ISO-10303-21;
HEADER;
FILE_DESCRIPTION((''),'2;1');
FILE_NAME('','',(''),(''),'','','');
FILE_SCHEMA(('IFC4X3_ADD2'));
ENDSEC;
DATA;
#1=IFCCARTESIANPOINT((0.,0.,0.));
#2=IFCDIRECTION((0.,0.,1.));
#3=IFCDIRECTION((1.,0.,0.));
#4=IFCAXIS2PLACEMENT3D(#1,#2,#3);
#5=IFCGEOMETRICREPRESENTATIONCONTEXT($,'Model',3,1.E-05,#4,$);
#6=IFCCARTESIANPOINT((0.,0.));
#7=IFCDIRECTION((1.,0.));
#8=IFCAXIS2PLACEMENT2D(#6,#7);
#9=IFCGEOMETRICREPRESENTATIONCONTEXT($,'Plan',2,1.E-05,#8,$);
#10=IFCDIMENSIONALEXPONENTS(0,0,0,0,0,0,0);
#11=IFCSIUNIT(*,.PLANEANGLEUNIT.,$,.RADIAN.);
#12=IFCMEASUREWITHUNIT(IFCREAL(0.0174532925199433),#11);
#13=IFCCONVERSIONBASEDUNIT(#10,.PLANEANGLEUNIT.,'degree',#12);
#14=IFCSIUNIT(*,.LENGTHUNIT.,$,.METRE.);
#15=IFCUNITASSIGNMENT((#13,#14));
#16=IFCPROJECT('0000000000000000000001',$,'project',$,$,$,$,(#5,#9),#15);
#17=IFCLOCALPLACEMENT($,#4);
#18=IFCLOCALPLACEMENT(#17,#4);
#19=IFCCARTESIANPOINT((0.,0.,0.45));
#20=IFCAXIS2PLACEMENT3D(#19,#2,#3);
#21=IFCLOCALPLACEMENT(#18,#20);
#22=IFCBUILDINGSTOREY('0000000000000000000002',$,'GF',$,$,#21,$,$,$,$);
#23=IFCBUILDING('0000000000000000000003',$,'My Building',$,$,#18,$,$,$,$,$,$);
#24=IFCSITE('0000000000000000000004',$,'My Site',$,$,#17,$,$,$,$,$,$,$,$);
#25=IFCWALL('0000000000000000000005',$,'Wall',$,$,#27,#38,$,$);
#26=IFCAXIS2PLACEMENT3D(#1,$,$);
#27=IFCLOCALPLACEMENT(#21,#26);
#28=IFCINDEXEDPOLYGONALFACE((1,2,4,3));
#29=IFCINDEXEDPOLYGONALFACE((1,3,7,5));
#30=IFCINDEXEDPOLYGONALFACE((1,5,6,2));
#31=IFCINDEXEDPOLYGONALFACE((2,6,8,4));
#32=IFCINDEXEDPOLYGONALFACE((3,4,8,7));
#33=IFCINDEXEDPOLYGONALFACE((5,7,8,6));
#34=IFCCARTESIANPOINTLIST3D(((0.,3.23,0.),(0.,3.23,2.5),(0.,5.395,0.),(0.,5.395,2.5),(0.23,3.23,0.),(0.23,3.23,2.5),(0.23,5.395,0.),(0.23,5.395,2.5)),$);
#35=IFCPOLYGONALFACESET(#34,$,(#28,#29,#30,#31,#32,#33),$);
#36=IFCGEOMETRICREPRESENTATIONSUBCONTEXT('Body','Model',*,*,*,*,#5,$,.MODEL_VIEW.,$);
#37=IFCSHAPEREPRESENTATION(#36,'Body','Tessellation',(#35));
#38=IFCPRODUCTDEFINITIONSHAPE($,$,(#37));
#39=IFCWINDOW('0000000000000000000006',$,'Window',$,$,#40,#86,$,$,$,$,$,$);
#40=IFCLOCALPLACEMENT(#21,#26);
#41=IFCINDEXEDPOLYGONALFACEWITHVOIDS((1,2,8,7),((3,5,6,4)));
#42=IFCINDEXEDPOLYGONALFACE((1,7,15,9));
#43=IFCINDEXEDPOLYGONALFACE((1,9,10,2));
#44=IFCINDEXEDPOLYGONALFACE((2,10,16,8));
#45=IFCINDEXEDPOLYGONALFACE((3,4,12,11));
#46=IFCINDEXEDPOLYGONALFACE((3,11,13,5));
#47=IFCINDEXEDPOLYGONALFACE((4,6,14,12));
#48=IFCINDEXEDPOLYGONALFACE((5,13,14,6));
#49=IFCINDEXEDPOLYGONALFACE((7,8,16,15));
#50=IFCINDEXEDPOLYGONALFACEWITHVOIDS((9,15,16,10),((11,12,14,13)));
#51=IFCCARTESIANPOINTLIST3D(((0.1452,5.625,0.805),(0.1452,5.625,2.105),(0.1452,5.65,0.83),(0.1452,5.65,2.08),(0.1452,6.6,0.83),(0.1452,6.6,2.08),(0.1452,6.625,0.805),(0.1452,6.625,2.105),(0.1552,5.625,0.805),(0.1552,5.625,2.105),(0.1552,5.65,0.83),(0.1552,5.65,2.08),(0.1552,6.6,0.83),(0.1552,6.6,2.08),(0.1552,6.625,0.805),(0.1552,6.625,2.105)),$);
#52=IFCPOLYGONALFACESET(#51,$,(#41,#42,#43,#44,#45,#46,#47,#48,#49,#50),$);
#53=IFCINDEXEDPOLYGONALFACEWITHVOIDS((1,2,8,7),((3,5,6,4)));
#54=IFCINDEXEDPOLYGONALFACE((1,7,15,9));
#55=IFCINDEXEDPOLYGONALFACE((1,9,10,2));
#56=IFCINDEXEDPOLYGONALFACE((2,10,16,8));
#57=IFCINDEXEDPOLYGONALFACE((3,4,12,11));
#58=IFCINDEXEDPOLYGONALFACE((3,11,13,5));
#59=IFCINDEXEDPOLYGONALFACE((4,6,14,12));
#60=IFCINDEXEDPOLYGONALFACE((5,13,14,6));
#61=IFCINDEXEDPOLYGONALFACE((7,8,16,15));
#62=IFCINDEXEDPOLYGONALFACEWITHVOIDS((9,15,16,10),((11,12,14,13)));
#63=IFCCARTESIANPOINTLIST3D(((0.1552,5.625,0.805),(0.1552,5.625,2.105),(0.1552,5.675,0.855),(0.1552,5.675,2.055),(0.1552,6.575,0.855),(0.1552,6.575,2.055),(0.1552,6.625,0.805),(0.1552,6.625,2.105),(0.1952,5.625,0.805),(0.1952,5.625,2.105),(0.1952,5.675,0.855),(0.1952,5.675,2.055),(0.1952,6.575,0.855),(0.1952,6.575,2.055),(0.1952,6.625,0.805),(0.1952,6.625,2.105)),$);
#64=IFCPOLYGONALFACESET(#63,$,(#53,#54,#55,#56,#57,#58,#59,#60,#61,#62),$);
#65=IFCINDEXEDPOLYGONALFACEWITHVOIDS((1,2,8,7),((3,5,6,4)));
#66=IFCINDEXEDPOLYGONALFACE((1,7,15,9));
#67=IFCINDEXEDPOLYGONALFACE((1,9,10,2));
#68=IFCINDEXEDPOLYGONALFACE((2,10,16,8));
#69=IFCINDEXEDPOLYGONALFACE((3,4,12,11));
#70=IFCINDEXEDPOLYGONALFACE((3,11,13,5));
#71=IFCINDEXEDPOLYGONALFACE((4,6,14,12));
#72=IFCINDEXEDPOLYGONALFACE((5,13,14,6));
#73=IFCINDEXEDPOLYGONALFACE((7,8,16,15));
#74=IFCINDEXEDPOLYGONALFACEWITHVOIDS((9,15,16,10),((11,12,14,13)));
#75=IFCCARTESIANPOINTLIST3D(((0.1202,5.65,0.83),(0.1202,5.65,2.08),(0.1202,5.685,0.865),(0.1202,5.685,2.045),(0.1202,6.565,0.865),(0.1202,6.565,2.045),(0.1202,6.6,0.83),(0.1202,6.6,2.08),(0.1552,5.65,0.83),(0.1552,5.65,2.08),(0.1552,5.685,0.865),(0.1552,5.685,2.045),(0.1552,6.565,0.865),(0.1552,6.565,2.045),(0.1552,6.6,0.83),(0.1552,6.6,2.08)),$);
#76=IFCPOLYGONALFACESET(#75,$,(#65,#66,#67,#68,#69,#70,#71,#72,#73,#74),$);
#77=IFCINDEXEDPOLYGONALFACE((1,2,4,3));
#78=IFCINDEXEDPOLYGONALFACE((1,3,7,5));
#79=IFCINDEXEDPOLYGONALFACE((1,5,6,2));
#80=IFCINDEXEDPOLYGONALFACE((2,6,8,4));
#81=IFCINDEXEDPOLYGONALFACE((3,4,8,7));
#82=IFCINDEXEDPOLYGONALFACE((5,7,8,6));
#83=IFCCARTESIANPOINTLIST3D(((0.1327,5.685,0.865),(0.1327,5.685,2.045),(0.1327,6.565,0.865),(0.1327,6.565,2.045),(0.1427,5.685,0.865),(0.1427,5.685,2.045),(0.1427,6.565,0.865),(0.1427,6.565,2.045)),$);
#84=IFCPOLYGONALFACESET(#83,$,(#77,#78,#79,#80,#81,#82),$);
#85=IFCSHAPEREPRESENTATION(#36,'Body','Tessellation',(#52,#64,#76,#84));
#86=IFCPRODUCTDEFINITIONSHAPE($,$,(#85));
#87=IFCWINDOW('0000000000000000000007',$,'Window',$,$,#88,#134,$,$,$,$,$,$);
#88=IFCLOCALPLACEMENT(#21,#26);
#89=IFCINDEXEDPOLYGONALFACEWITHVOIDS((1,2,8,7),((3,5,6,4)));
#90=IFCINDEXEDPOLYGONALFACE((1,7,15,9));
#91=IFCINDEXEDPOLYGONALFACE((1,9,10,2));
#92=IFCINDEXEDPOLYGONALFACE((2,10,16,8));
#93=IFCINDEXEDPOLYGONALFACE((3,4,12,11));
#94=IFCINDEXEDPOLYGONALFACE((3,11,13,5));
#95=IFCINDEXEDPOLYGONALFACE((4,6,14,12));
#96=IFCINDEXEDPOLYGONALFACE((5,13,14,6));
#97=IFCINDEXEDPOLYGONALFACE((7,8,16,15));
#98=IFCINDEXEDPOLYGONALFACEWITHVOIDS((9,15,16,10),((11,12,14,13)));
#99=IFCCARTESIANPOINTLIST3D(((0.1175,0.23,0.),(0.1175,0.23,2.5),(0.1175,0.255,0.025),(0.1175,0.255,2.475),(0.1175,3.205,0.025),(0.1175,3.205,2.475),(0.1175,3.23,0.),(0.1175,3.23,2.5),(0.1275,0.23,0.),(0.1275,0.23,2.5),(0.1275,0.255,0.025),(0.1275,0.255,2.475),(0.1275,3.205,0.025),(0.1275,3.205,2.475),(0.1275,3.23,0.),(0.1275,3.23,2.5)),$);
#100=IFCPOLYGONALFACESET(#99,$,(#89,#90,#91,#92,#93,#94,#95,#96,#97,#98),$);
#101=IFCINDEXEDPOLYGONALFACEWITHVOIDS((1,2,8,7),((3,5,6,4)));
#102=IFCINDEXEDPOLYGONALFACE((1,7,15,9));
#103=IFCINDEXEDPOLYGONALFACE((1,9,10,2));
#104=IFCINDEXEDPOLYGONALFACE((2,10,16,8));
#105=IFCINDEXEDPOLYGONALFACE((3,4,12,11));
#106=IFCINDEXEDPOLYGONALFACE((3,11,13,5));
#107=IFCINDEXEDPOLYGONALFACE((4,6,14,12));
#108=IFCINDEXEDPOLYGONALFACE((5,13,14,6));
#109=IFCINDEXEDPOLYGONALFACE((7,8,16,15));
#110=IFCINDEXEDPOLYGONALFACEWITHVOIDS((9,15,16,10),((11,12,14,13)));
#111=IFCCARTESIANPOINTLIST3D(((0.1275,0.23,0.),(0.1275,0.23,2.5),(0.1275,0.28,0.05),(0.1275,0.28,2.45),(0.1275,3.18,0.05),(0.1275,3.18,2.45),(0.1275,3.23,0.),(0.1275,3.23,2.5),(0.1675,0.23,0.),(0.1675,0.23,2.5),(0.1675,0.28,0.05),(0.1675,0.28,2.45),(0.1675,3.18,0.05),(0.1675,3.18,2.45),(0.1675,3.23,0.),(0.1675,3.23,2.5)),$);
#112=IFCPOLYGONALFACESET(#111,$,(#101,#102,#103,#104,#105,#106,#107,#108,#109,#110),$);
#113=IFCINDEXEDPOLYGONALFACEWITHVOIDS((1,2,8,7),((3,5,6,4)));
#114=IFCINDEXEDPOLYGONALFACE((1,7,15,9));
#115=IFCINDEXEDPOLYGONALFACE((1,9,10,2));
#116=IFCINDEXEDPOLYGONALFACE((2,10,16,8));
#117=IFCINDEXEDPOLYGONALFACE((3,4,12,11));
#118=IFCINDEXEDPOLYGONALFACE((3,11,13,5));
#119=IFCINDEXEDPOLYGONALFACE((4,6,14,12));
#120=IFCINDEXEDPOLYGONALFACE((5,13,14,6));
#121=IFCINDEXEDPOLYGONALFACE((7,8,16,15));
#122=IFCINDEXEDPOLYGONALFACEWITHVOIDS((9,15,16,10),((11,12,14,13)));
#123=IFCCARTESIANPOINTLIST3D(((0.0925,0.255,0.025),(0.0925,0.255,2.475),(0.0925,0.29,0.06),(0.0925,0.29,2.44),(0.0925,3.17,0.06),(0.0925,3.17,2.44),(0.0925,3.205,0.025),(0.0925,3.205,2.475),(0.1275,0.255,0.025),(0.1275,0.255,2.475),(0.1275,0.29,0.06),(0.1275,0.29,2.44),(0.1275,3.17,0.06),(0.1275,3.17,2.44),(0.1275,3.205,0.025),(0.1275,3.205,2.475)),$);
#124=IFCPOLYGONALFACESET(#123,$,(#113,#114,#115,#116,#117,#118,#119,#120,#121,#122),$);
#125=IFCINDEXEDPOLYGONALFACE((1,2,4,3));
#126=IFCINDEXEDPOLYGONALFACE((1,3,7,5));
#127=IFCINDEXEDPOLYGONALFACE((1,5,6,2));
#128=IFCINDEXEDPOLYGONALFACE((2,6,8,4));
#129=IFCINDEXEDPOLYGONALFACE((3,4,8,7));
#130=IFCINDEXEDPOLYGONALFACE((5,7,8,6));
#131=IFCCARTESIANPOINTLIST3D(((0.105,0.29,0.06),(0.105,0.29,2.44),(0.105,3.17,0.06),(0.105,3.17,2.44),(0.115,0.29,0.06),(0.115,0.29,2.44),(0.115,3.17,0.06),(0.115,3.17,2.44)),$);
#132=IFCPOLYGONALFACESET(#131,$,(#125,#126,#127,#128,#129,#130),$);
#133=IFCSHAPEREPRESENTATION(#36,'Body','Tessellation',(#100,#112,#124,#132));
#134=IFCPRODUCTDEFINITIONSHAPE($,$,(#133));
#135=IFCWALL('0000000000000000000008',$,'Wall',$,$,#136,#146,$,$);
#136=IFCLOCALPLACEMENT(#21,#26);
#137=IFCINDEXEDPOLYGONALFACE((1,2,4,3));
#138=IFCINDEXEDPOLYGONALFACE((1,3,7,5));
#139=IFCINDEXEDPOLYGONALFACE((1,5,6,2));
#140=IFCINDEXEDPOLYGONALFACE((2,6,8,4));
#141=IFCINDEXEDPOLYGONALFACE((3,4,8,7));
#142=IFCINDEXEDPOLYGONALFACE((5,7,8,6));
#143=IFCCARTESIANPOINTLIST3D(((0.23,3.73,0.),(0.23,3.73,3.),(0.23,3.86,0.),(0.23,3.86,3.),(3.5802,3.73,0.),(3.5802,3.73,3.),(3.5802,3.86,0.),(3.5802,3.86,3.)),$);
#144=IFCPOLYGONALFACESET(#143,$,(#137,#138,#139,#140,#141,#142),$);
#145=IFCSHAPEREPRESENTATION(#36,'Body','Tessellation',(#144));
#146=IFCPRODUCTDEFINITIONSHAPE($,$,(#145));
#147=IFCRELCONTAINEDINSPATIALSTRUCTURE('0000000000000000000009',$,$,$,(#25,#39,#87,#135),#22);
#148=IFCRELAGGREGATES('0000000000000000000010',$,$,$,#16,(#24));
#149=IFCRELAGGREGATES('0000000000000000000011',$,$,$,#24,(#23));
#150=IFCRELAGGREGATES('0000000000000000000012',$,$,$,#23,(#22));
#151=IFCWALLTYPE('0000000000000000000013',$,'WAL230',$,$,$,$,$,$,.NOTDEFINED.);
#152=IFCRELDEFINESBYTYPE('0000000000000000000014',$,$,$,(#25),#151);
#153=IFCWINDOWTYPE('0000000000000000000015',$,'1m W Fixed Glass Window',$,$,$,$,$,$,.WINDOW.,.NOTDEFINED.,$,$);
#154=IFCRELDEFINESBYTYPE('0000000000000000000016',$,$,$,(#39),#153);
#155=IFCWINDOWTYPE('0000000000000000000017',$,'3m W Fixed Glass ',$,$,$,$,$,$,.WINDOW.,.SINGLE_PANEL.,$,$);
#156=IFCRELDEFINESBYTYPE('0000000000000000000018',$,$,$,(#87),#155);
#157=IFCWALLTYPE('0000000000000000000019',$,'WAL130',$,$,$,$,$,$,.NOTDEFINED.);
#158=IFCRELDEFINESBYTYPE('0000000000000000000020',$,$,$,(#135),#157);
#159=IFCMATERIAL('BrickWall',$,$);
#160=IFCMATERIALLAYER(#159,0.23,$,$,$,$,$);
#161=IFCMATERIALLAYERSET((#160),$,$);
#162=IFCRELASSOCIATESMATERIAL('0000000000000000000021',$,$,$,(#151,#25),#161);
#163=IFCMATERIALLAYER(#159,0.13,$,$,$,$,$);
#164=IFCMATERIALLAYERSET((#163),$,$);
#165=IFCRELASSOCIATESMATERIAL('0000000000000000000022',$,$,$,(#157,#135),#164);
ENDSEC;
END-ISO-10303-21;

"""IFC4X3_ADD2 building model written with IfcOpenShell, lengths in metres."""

from ifc_helpers import new_model, entity, si_unit, converted_unit, frame, origin_with_axes, origin_2d_with_axis, place, context, subcontext, project, spatial, line, indexed_curve, outline, extrude, shape, source, transform, mapped, material, layer, layer_set, layer_usage, type_object, type_shapes, element, fill, save


model = new_model("IFC4X3_ADD2")

# Units and contexts
model_context = context("Model", 3, precision=1e-05, world=origin_with_axes())
plan_context = context("Plan", 2, precision=1e-05, world=origin_2d_with_axis())
body_context_1 = subcontext(model_context, "Body", "Model", "MODEL_VIEW")
body_context_2 = subcontext(plan_context, "Body", "Plan", "PLAN_VIEW")
ifc_project = project(units=[converted_unit("PLANEANGLEUNIT", "degree", entity("IfcReal", 0.0174532925199433), si_unit("PLANEANGLEUNIT", "RADIAN"), dimensions=[0, 0, 0, 0, 0, 0, 0]), si_unit("LENGTHUNIT", "METRE")], contexts=[model_context, plan_context])

# Site, building, storey
site_placement = place(None, origin_with_axes())
site = spatial("IfcSite", under=ifc_project, at=site_placement, Name="My Site")
building_placement = place(site_placement, origin_with_axes())
building = spatial("IfcBuilding", under=site, at=building_placement, Name="My Building")
storey_placement = place(building_placement, frame((0.0, 0.0, 0.45), z_axis=(0.0, 0.0, 1.0), x_axis=(1.0, 0.0, 0.0)))
storey = spatial("IfcBuildingStorey", under=building, at=storey_placement, Name="GF")

# Shared definitions
ifc_material_1 = material(Name="BrickWall")

# Wall, openings, windows
ifc_layer_1 = layer(ifc_material_1, 0.23)
ifc_layer_set_1 = layer_set([ifc_layer_1])
ifc_layer_usage_1 = layer_usage(ifc_layer_set_1, "AXIS2", "POSITIVE", 0.0)
wall_type_1 = type_object("IfcWallType", Name="WAL230", PredefinedType="NOTDEFINED", material=ifc_layer_set_1)
wall_1_placement = place(storey_placement, frame((0.23, 0.2325, 0.0), z_axis=(0.0, 0.0, 1.0), x_axis=(0.0, 1.0, 0.0)))
wall_1 = element("IfcWall", 1, at=wall_1_placement, inside=storey, type_object=wall_type_1, material=ifc_layer_usage_1, Name="Wall", context=body_context_1, shape_type="SweptSolid", body=[
    extrude(outline(indexed_curve([(0.0, 0.0), (0.0, 0.23), (5.1625, 0.23), (5.1625, 0.0), (0.0, 0.0)], self_intersect=False)), origin_with_axes(), (0.0, 0.0, 1.0), 2.5),
])
shared_shape_1 = source(origin_with_axes(), body_context_1, "Body", "SweptSolid", [
    extrude(outline(indexed_curve([(0.0, 0.0), (1.0, 0.0), (1.0, 1.3), (0.0, 1.3)], segments=[line(1, 2, 3, 4, 1)])), frame((0.0, -0.6, 0.0), z_axis=(0.0, -1.0, 0.0), x_axis=(1.0, 0.0, 0.0)), (0.0, 0.0, -1.0), 1.2),
])
opening_1_placement = place(wall_1_placement, frame((5.3925, -0.0152, 0.805), z_axis=(0.0, 0.0, 1.0), x_axis=(1.0, 0.0, 0.0)))
opening_1 = element("IfcOpeningElement", 2, at=opening_1_placement, cuts=wall_1, PredefinedType="OPENING", context=body_context_1, shape_type="MappedRepresentation", body=[
    mapped(shared_shape_1, transform((0.0, 0.0, 0.0), x_axis=(1.0, 0.0, 0.0), y_axis=(0.0, 1.0, 0.0), z_axis=(0.0, 0.0, 1.0), scale=1.0)),
])
shared_shape_2 = source(origin_with_axes(), body_context_1, "Body", "SweptSolid", [
    extrude(outline(indexed_curve([(0.0, 0.0), (3.0, 0.0), (3.0, 2.5), (0.0, 2.5)], segments=[line(1, 2, 3, 4, 1)])), frame((0.0, -0.6, 0.0), z_axis=(0.0, -1.0, 0.0), x_axis=(1.0, 0.0, 0.0)), (0.0, 0.0, -1.0), 1.2),
])
opening_2_placement = place(wall_1_placement, frame((-0.0025, 0.0125, 0.0), z_axis=(0.0, 0.0, 1.0), x_axis=(1.0, 0.0, 0.0)))
opening_2 = element("IfcOpeningElement", 3, at=opening_2_placement, cuts=wall_1, PredefinedType="OPENING", context=body_context_1, shape_type="MappedRepresentation", body=[
    mapped(shared_shape_2, transform((0.0, 0.0, 0.0), x_axis=(1.0, 0.0, 0.0), y_axis=(0.0, 1.0, 0.0), z_axis=(0.0, 0.0, 1.0), scale=1.0)),
])
window_type_1 = type_object("IfcWindowType", Name="1m W Fixed Glass Window", PartitioningType="NOTDEFINED", PredefinedType="WINDOW")
shared_shape_3 = source(origin_with_axes(), body_context_1, "Body", "SweptSolid", [
    extrude(outline(indexed_curve([(0.0, 0.0), (1.0, 0.0), (1.0, 1.3), (0.0, 1.3)], segments=[line(1, 2, 3, 4, 1)]), holes=[indexed_curve([(0.025, 0.025), (0.975, 0.025), (0.975, 1.275), (0.025, 1.275)], segments=[line(1, 2, 3, 4, 1)])]), frame((0.0, 0.09, 0.0), z_axis=(0.0, -1.0, 0.0), x_axis=(1.0, 0.0, 0.0)), (0.0, 0.0, -1.0), 0.01),
    extrude(outline(indexed_curve([(0.0, 0.0), (1.0, 0.0), (1.0, 1.3), (0.0, 1.3)], segments=[line(1, 2, 3, 4, 1)]), holes=[indexed_curve([(0.05, 0.05), (0.95, 0.05), (0.95, 1.25), (0.05, 1.25)], segments=[line(1, 2, 3, 4, 1)])]), frame((0.0, 0.05, 0.0), z_axis=(0.0, -1.0, 0.0), x_axis=(1.0, 0.0, 0.0)), (0.0, 0.0, -1.0), 0.04),
    extrude(outline(indexed_curve([(0.0, 0.0), (0.95, 0.0), (0.95, 1.25), (0.0, 1.25)], segments=[line(1, 2, 3, 4, 1)]), holes=[indexed_curve([(0.035, 0.035), (0.915, 0.035), (0.915, 1.215), (0.035, 1.215)], segments=[line(1, 2, 3, 4, 1)])]), frame((0.025, 0.09, 0.025), z_axis=(0.0, -1.0, 0.0), x_axis=(1.0, 0.0, 0.0)), (0.0, 0.0, -1.0), 0.035),
    extrude(outline(indexed_curve([(0.035, 0.035), (0.915, 0.035), (0.915, 1.215), (0.035, 1.215)], segments=[line(1, 2, 3, 4, 1)])), frame((0.025, 0.1025, 0.025), z_axis=(0.0, -1.0, 0.0), x_axis=(1.0, 0.0, 0.0)), (0.0, 0.0, -1.0), 0.01),
])
shared_shape_4 = source(origin_with_axes(), body_context_2, "Body", "Curve2D", [
    entity("IfcIndexedPolyCurve", entity("IfcCartesianPointList2D", [[0.05, 0.05], [0.95, 0.05]])),
    entity("IfcIndexedPolyCurve", entity("IfcCartesianPointList2D", [[0.0, 0.1], [0.025, 0.1], [0.025, 0.09], [0.05, 0.09], [0.05, 0.05], [0.0, 0.05]]), [entity("IfcLineIndex", [1, 2, 3, 4, 5, 6, 1])]),
    entity("IfcIndexedPolyCurve", entity("IfcCartesianPointList2D", [[1.0, 0.1], [0.975, 0.1], [0.975, 0.09], [0.95, 0.09], [0.95, 0.05], [1.0, 0.05]]), [entity("IfcLineIndex", [1, 2, 3, 4, 5, 6, 1])]),
    entity("IfcIndexedPolyCurve", entity("IfcCartesianPointList2D", [[0.025, 0.09], [0.06, 0.09], [0.06, 0.125], [0.025, 0.125]]), [entity("IfcLineIndex", [1, 2, 3, 4, 1])]),
    entity("IfcIndexedPolyCurve", entity("IfcCartesianPointList2D", [[0.975, 0.09], [0.94, 0.09], [0.94, 0.125], [0.975, 0.125]]), [entity("IfcLineIndex", [1, 2, 3, 4, 1])]),
    entity("IfcIndexedPolyCurve", entity("IfcCartesianPointList2D", [[0.06, 0.09], [0.94, 0.09]])),
    entity("IfcIndexedPolyCurve", entity("IfcCartesianPointList2D", [[0.06, 0.125], [0.94, 0.125]])),
    entity("IfcIndexedPolyCurve", entity("IfcCartesianPointList2D", [[0.06, 0.1075], [0.94, 0.1075]])),
])
type_shapes(window_type_1, [shared_shape_3, shared_shape_4])
window_1_placement = place(opening_1_placement, frame((0.0, 0.0, 0.0), z_axis=(0.0, 0.0, 1.0), x_axis=(1.0, 0.0, 0.0)))
window_1 = element("IfcWindow", 4, at=window_1_placement, inside=storey, type_object=window_type_1, Name="Window", shapes=[
    shape(body_context_1, "Body", "MappedRepresentation", [mapped(shared_shape_3, transform((0.0, 0.0, 0.0), x_axis=(1.0, 0.0, 0.0), y_axis=(0.0, 1.0, 0.0), z_axis=(0.0, 0.0, 1.0), scale=1.0))]),
    shape(body_context_2, "Body", "MappedRepresentation", [mapped(shared_shape_4, transform((0.0, 0.0, 0.0), x_axis=(1.0, 0.0, 0.0), y_axis=(0.0, 1.0, 0.0), z_axis=(0.0, 0.0, 1.0), scale=1.0))]),
])
fill(opening_1, window_1)
window_type_2 = type_object("IfcWindowType", Name="3m W Fixed Glass ", PartitioningType="SINGLE_PANEL", PredefinedType="WINDOW")
shared_shape_5 = source(origin_with_axes(), body_context_1, "Body", "SweptSolid", [
    extrude(outline(indexed_curve([(0.0, 0.0), (3.0, 0.0), (3.0, 2.5), (0.0, 2.5)], segments=[line(1, 2, 3, 4, 1)]), holes=[indexed_curve([(0.025, 0.025), (2.975, 0.025), (2.975, 2.475), (0.025, 2.475)], segments=[line(1, 2, 3, 4, 1)])]), frame((0.0, 0.09, 0.0), z_axis=(0.0, -1.0, 0.0), x_axis=(1.0, 0.0, 0.0)), (0.0, 0.0, -1.0), 0.01),
    extrude(outline(indexed_curve([(0.0, 0.0), (3.0, 0.0), (3.0, 2.5), (0.0, 2.5)], segments=[line(1, 2, 3, 4, 1)]), holes=[indexed_curve([(0.05, 0.05), (2.95, 0.05), (2.95, 2.45), (0.05, 2.45)], segments=[line(1, 2, 3, 4, 1)])]), frame((0.0, 0.05, 0.0), z_axis=(0.0, -1.0, 0.0), x_axis=(1.0, 0.0, 0.0)), (0.0, 0.0, -1.0), 0.04),
    extrude(outline(indexed_curve([(0.0, 0.0), (2.95, 0.0), (2.95, 2.45), (0.0, 2.45)], segments=[line(1, 2, 3, 4, 1)]), holes=[indexed_curve([(0.035, 0.035), (2.915, 0.035), (2.915, 2.415), (0.035, 2.415)], segments=[line(1, 2, 3, 4, 1)])]), frame((0.025, 0.09, 0.025), z_axis=(0.0, -1.0, 0.0), x_axis=(1.0, 0.0, 0.0)), (0.0, 0.0, -1.0), 0.035),
    extrude(outline(indexed_curve([(0.035, 0.035), (2.915, 0.035), (2.915, 2.415), (0.035, 2.415)], segments=[line(1, 2, 3, 4, 1)])), frame((0.025, 0.1025, 0.025), z_axis=(0.0, -1.0, 0.0), x_axis=(1.0, 0.0, 0.0)), (0.0, 0.0, -1.0), 0.01),
])
shared_shape_6 = source(origin_with_axes(), body_context_2, "Body", "Curve2D", [
    entity("IfcIndexedPolyCurve", entity("IfcCartesianPointList2D", [[0.05, 0.05], [2.95, 0.05]])),
    entity("IfcIndexedPolyCurve", entity("IfcCartesianPointList2D", [[0.0, 0.1], [0.025, 0.1], [0.025, 0.09], [0.05, 0.09], [0.05, 0.05], [0.0, 0.05]]), [entity("IfcLineIndex", [1, 2, 3, 4, 5, 6, 1])]),
    entity("IfcIndexedPolyCurve", entity("IfcCartesianPointList2D", [[3.0, 0.1], [2.975, 0.1], [2.975, 0.09], [2.95, 0.09], [2.95, 0.05], [3.0, 0.05]]), [entity("IfcLineIndex", [1, 2, 3, 4, 5, 6, 1])]),
    entity("IfcIndexedPolyCurve", entity("IfcCartesianPointList2D", [[0.025, 0.09], [0.06, 0.09], [0.06, 0.125], [0.025, 0.125]]), [entity("IfcLineIndex", [1, 2, 3, 4, 1])]),
    entity("IfcIndexedPolyCurve", entity("IfcCartesianPointList2D", [[2.975, 0.09], [2.94, 0.09], [2.94, 0.125], [2.975, 0.125]]), [entity("IfcLineIndex", [1, 2, 3, 4, 1])]),
    entity("IfcIndexedPolyCurve", entity("IfcCartesianPointList2D", [[0.06, 0.09], [2.94, 0.09]])),
    entity("IfcIndexedPolyCurve", entity("IfcCartesianPointList2D", [[0.06, 0.125], [2.94, 0.125]])),
    entity("IfcIndexedPolyCurve", entity("IfcCartesianPointList2D", [[0.06, 0.1075], [2.94, 0.1075]])),
])
type_shapes(window_type_2, [shared_shape_5, shared_shape_6])
window_2_placement = place(opening_2_placement, origin_with_axes())
window_2 = element("IfcWindow", 5, at=window_2_placement, inside=storey, type_object=window_type_2, Name="Window", shapes=[
    shape(body_context_1, "Body", "MappedRepresentation", [mapped(shared_shape_5, transform((0.0, 0.0, 0.0), x_axis=(1.0, 0.0, 0.0), y_axis=(0.0, 1.0, 0.0), z_axis=(0.0, 0.0, 1.0), scale=1.0))]),
    shape(body_context_2, "Body", "MappedRepresentation", [mapped(shared_shape_6, transform((0.0, 0.0, 0.0), x_axis=(1.0, 0.0, 0.0), y_axis=(0.0, 1.0, 0.0), z_axis=(0.0, 0.0, 1.0), scale=1.0))]),
])
fill(opening_2, window_2)

# Wall
ifc_layer_2 = layer(ifc_material_1, 0.13)
ifc_layer_set_2 = layer_set([ifc_layer_2])
ifc_layer_usage_2 = layer_usage(ifc_layer_set_2, "AXIS2", "POSITIVE", 0.0)
wall_type_2 = type_object("IfcWallType", Name="WAL130", PredefinedType="NOTDEFINED", material=ifc_layer_set_2)
wall_2_placement = place(storey_placement, frame((0.23, 3.73, 0.0), z_axis=(0.0, 0.0, 1.0), x_axis=(1.0, 0.0, 0.0)))
element("IfcWall", 6, at=wall_2_placement, inside=storey, type_object=wall_type_2, material=ifc_layer_usage_2, Name="Wall", context=body_context_1, shape_type="SweptSolid", body=[
    extrude(outline(indexed_curve([(0.0, 0.0), (0.0, 0.13), (3.3502, 0.13), (3.3502, 0.0), (0.0, 0.0)], self_intersect=False)), origin_with_axes(), (0.0, 0.0, 1.0), 3.0),
])

save(model, "model.ifc")
